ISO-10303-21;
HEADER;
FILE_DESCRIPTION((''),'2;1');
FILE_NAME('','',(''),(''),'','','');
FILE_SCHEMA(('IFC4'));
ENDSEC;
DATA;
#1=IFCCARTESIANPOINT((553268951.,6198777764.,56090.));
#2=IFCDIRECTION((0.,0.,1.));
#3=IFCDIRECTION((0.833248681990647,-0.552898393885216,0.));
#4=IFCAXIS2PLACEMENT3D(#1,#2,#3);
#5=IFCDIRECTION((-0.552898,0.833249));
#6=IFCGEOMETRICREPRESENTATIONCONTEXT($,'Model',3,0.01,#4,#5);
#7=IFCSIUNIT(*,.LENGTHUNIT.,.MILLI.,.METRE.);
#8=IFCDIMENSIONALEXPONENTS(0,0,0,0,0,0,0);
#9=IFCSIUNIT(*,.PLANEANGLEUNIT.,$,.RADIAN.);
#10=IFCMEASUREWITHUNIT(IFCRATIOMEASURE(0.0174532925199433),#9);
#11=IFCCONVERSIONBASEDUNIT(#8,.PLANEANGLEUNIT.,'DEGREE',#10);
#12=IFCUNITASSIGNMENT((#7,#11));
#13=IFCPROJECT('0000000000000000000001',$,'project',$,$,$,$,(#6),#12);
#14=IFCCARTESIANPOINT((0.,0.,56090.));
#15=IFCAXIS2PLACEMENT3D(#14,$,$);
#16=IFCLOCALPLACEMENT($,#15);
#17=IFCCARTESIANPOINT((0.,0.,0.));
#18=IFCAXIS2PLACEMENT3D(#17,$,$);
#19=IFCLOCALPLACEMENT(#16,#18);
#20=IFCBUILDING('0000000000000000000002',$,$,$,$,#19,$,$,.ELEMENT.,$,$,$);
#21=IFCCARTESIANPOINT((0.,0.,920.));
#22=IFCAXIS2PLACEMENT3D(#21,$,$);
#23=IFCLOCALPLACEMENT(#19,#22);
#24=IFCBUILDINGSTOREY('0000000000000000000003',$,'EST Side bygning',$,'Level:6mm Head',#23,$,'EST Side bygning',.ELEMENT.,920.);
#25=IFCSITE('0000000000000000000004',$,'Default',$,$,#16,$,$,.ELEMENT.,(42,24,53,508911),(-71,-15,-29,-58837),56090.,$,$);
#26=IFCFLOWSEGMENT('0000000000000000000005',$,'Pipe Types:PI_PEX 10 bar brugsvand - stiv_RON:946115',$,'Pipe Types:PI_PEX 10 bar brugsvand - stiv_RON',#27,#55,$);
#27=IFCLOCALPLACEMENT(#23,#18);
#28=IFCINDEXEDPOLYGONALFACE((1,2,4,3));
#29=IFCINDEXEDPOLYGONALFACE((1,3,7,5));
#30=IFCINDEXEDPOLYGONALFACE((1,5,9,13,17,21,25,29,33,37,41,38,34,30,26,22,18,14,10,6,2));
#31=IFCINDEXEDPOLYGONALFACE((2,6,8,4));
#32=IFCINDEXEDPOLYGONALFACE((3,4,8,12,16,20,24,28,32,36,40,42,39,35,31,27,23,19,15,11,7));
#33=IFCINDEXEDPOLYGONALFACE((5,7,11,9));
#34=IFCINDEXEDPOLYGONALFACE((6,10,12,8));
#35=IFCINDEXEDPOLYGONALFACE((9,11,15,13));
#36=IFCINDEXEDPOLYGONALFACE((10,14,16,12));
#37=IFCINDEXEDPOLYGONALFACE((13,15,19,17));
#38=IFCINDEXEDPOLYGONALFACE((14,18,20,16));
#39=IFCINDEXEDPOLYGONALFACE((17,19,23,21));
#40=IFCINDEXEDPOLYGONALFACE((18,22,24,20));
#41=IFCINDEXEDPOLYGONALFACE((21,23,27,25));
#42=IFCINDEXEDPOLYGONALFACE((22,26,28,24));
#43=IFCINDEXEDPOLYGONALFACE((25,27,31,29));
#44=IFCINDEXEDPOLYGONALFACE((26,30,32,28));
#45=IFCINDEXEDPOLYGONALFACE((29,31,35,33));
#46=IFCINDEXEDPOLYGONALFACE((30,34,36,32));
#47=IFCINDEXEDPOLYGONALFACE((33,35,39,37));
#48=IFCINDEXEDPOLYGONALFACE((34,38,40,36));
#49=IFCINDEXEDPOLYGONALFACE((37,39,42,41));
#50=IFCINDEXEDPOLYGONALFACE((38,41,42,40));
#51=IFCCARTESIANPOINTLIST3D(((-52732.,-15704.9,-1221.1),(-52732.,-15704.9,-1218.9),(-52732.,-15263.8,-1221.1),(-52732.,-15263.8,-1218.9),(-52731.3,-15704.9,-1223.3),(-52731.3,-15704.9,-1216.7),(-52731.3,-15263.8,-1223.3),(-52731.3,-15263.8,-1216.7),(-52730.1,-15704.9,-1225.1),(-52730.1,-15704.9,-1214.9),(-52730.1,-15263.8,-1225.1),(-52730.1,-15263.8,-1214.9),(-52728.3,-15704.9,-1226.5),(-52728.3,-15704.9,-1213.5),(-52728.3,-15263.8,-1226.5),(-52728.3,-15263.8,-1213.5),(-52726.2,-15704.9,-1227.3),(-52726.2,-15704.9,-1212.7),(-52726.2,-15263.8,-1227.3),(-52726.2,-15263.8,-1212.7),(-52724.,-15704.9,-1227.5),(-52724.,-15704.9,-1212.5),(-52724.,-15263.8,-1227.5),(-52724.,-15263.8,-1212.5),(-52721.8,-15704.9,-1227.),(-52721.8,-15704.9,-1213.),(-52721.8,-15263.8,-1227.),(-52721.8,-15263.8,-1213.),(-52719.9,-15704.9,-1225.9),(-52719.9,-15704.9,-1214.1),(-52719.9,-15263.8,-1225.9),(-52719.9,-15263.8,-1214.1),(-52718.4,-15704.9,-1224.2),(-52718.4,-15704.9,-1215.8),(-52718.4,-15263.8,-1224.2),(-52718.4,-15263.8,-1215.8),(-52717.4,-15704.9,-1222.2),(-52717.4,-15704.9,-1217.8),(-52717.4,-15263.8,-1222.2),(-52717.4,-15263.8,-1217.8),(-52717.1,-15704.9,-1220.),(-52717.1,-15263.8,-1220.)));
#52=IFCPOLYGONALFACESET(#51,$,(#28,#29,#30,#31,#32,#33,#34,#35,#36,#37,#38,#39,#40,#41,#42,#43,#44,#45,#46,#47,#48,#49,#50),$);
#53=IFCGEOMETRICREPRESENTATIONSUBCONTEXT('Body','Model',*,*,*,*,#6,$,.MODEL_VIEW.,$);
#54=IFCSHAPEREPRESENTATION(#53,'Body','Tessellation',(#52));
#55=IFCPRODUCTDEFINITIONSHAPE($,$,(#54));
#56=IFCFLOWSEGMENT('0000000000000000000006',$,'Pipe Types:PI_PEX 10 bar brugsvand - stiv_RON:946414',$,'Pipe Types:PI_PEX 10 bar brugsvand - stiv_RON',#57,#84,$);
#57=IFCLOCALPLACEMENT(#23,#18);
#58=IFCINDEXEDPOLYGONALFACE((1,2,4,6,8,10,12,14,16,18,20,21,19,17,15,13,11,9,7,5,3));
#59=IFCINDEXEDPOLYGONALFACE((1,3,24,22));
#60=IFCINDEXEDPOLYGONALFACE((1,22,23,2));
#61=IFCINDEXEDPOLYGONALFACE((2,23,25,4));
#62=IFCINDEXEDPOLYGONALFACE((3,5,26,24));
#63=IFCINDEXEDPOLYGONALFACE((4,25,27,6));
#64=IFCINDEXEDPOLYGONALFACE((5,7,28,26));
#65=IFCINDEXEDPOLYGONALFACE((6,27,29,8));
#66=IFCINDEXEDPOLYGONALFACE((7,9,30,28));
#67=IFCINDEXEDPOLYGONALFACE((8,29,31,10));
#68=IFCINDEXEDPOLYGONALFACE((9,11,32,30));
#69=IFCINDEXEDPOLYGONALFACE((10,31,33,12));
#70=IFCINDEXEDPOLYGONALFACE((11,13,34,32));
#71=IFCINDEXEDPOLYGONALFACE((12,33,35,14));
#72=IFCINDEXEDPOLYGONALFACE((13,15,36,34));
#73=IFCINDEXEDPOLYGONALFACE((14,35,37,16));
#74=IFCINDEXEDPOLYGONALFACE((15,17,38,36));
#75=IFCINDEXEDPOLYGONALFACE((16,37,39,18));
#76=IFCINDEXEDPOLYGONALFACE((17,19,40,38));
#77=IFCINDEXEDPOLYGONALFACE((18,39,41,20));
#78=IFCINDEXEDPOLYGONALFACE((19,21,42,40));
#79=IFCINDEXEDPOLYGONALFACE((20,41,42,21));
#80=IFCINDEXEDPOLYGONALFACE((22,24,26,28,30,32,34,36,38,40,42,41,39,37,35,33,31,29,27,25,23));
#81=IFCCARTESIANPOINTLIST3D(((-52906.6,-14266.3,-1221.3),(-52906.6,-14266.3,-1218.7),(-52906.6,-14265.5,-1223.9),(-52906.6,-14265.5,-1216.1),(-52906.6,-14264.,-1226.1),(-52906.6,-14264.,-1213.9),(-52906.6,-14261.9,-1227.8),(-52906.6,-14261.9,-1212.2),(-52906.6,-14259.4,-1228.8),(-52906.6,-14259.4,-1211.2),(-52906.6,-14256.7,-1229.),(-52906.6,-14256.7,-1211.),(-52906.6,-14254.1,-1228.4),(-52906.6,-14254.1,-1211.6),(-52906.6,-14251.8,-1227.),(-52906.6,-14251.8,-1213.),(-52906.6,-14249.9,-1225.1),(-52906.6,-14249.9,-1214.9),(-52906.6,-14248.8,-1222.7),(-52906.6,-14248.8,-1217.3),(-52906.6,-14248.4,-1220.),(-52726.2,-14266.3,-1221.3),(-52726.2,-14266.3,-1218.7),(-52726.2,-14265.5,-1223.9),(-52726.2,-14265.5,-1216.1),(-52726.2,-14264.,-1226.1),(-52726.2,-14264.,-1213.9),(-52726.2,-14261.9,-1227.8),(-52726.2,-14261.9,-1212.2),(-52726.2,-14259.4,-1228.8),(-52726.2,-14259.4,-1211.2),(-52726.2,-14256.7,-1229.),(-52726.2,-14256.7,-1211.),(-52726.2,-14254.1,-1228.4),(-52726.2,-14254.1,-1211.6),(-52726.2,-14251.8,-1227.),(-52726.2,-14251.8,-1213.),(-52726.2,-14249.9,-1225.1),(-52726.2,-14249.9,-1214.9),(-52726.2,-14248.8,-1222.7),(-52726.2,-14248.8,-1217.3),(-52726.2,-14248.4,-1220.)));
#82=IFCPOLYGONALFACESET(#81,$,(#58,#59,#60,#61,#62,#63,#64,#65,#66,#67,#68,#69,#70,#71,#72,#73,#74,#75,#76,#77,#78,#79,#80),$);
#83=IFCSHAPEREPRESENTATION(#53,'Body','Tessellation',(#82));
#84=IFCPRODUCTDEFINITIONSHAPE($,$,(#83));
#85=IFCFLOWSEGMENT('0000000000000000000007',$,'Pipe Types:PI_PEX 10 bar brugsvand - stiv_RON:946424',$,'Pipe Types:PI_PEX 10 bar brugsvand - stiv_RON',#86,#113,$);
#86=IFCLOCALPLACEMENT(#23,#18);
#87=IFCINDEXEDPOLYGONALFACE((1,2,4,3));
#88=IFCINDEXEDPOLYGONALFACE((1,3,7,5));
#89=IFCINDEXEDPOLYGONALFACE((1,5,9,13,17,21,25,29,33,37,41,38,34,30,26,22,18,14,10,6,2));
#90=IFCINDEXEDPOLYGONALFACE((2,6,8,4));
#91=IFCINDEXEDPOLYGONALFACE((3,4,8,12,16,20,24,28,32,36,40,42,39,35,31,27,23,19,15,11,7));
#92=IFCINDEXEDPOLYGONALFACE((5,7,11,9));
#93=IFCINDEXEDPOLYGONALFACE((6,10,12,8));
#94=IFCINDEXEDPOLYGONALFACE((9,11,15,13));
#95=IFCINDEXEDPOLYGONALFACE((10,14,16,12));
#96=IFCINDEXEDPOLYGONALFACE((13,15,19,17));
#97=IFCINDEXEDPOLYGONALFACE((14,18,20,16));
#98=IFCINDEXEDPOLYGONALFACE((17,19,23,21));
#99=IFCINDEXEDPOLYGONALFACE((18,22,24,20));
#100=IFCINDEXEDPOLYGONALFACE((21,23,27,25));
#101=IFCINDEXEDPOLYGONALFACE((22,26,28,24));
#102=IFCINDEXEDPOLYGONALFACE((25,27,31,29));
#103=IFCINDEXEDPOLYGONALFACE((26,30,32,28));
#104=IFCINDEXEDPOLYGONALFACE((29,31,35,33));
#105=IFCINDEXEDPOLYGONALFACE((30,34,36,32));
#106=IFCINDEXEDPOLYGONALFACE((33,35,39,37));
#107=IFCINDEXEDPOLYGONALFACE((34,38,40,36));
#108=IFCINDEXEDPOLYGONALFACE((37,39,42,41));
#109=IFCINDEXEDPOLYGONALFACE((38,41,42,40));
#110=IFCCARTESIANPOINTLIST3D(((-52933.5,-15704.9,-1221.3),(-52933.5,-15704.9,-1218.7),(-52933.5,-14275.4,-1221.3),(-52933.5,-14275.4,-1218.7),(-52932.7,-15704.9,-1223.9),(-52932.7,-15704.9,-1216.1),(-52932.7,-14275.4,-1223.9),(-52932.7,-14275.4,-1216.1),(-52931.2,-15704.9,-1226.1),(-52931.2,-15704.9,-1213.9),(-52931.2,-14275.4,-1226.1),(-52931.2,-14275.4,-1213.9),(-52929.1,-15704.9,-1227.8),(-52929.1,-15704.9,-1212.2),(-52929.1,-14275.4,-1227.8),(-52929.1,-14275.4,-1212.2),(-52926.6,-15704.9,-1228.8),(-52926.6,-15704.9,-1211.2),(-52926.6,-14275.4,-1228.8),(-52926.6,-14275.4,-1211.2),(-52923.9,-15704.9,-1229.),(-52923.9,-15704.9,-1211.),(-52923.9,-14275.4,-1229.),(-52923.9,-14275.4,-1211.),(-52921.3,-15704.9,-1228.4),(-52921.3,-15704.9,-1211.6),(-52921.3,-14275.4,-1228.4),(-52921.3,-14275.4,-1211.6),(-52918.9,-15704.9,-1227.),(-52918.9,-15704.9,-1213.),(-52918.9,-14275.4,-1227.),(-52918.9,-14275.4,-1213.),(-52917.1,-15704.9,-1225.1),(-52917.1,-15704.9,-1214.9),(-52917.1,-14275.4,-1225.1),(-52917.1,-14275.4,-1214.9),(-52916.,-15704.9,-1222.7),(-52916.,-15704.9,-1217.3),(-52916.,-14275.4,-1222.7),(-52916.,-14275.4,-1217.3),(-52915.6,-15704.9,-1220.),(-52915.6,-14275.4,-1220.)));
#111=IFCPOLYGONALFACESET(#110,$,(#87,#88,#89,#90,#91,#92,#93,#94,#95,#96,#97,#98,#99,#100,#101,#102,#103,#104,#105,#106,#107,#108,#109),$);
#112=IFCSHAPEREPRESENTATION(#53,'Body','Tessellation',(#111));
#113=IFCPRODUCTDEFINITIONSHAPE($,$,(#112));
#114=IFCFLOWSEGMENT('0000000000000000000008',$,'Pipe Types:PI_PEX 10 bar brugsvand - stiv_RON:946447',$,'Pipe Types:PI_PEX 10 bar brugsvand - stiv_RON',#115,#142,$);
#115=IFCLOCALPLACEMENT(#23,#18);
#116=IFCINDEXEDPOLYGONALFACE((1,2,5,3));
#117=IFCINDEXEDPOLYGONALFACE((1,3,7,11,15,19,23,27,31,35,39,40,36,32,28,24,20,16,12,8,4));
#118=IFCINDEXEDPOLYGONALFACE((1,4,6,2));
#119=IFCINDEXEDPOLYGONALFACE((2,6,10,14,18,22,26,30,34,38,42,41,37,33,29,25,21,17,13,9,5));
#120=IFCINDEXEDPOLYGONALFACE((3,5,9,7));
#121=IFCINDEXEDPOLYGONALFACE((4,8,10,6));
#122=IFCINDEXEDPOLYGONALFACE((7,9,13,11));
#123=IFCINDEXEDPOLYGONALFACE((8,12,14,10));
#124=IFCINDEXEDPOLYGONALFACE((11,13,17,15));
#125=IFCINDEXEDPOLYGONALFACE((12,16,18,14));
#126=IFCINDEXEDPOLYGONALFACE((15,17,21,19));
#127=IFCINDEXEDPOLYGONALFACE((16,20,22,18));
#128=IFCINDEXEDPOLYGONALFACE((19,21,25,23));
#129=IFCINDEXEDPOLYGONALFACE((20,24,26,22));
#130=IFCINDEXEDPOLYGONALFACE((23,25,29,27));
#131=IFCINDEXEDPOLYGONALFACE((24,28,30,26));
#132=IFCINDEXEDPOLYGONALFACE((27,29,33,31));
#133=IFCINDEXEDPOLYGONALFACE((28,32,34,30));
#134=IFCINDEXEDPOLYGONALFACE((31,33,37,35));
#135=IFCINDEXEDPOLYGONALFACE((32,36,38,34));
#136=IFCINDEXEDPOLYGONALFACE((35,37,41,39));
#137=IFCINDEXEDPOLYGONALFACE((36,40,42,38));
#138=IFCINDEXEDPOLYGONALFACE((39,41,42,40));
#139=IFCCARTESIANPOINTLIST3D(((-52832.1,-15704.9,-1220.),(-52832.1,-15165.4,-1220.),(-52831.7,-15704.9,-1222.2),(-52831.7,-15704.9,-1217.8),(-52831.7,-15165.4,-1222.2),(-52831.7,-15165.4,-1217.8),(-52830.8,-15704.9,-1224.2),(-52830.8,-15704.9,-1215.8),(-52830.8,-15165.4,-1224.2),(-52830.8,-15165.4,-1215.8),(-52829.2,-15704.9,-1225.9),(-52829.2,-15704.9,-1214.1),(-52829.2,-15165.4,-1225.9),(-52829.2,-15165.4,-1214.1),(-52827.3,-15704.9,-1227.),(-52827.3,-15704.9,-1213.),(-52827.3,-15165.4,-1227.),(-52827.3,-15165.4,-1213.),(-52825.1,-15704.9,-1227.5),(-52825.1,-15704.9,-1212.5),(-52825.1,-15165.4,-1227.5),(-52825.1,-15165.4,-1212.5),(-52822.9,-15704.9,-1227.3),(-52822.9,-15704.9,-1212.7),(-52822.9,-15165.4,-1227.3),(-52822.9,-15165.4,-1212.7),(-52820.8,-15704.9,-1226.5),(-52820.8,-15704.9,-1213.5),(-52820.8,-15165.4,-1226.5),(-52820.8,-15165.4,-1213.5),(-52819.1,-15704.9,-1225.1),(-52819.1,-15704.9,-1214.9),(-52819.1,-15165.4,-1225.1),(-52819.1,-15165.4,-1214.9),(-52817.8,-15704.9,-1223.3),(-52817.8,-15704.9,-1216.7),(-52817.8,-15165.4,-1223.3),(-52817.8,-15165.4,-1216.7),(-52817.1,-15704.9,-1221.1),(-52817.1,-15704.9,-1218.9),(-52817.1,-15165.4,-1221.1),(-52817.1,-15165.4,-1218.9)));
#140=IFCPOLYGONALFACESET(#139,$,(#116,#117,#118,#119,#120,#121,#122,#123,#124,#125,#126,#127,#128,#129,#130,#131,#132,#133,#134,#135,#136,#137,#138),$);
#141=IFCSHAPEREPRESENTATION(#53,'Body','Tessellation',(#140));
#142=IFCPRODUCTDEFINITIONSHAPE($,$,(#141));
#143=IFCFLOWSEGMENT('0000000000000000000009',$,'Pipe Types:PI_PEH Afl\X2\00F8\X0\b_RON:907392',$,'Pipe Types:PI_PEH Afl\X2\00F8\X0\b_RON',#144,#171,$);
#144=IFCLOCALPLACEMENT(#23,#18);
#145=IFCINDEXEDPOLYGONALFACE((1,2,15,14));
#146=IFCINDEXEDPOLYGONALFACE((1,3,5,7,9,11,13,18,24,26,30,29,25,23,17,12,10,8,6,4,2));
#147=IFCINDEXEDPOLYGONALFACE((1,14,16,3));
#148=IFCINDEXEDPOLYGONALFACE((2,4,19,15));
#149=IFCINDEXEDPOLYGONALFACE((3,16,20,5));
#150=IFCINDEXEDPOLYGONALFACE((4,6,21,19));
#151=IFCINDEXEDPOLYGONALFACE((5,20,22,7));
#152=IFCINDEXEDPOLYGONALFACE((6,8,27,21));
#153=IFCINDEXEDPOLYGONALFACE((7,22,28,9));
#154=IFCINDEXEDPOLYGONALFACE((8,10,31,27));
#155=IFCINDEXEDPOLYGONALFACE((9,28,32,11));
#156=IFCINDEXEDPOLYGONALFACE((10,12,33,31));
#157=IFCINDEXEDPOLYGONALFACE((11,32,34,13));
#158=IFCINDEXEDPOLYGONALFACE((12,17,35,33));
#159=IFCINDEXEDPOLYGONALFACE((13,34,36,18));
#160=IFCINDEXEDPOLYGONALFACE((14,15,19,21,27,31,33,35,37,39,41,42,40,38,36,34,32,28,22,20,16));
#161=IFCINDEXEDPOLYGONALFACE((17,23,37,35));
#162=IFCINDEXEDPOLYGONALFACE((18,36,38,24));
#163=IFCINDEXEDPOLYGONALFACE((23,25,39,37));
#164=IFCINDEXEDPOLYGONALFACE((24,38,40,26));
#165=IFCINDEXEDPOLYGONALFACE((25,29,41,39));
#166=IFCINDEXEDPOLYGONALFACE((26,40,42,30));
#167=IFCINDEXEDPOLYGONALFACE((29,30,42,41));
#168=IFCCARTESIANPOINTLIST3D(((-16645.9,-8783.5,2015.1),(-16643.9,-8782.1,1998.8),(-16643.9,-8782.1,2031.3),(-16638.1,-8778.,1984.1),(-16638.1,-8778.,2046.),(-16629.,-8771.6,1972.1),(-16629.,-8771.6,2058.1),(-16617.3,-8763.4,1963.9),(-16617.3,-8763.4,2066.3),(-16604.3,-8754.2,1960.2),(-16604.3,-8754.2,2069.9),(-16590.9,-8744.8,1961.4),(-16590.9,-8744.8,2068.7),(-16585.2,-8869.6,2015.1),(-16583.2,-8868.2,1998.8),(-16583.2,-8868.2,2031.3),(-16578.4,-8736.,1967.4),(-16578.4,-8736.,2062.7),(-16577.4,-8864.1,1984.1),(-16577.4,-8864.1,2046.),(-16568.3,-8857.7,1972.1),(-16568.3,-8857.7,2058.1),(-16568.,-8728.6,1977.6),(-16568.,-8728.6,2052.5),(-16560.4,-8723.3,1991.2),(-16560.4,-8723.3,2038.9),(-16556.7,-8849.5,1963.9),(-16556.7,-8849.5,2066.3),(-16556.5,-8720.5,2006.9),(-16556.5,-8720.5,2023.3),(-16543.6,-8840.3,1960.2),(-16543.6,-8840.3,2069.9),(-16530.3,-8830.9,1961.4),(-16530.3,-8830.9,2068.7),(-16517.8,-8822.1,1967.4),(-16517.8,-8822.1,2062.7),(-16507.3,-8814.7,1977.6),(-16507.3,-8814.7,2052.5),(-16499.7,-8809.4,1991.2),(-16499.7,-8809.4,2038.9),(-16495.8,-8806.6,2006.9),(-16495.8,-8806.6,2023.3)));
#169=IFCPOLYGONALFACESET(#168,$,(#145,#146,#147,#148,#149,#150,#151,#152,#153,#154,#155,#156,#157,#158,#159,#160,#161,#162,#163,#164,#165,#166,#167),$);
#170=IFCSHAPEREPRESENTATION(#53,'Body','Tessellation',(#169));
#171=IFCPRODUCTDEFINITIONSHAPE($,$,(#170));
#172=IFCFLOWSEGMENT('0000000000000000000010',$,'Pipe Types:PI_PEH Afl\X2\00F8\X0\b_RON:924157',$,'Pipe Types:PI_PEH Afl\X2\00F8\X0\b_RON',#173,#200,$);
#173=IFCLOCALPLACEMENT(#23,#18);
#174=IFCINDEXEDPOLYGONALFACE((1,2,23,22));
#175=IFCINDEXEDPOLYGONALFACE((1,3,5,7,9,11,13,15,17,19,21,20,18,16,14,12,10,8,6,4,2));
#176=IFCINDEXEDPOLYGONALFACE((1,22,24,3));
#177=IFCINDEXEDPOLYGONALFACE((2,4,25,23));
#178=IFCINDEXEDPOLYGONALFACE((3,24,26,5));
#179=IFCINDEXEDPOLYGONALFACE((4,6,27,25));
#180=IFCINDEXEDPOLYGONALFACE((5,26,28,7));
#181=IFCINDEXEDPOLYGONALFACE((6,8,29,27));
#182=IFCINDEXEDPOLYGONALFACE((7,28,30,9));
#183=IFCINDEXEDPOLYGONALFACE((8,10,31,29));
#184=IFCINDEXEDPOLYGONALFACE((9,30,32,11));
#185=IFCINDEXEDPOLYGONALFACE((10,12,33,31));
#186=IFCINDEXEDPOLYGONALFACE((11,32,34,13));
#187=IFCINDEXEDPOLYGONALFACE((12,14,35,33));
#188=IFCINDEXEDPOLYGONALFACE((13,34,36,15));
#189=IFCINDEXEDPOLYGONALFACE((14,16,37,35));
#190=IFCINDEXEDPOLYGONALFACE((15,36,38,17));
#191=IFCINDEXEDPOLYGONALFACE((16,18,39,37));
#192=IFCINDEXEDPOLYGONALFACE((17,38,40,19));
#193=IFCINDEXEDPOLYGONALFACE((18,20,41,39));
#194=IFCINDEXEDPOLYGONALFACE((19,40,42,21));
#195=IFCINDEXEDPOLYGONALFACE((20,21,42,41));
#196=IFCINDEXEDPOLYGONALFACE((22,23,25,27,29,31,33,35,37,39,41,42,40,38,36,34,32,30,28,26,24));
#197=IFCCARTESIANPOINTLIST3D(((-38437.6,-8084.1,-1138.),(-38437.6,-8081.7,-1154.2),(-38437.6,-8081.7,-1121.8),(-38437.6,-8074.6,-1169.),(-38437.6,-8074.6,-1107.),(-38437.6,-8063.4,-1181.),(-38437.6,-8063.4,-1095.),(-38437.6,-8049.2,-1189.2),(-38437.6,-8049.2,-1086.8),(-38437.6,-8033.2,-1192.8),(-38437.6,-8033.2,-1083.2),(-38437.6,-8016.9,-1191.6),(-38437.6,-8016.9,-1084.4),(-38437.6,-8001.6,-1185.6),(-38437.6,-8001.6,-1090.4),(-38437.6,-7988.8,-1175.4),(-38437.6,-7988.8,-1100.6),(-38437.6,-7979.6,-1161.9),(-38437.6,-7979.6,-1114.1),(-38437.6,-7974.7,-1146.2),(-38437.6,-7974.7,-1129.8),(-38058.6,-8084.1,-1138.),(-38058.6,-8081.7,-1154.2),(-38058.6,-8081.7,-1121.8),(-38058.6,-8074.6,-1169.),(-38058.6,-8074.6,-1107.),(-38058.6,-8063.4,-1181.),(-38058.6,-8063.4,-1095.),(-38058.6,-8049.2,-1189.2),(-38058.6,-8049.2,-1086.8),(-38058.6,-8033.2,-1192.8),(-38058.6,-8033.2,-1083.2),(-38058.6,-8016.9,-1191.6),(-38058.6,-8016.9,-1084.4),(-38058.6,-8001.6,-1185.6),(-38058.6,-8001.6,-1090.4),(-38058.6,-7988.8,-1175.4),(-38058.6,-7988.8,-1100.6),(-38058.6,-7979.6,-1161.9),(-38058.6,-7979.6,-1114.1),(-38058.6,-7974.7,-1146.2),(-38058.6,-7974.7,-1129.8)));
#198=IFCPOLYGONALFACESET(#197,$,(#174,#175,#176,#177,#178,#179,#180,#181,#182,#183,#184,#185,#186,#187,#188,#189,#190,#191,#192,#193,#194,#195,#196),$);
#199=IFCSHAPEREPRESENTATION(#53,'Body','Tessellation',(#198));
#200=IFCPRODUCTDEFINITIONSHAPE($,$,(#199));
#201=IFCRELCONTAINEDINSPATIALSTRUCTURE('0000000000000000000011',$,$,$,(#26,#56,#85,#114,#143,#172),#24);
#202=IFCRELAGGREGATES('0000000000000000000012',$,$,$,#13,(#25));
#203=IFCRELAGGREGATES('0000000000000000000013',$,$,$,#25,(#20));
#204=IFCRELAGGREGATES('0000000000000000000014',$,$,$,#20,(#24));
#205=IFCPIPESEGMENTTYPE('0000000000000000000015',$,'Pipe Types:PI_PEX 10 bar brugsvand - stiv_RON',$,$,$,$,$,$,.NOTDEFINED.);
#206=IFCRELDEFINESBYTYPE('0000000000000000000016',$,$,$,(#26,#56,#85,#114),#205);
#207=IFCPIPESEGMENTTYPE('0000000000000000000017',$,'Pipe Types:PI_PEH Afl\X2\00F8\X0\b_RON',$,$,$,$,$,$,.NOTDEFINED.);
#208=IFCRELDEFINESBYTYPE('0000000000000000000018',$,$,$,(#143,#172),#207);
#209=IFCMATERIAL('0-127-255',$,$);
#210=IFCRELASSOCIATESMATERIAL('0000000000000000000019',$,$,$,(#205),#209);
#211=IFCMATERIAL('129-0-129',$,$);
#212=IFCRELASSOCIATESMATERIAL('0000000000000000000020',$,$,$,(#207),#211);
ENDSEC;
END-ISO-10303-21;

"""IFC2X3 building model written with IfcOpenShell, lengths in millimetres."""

from ifc_helpers import new_model, entity, si_unit, converted_unit, direction, frame, frame_2d, origin, origin_2d_with_axis, place, context, subcontext, project, spatial, circle, extrude, material, type_object, element, save


model = new_model("IFC2X3")

# Units and contexts
model_context = context("Model", 3, precision=0.01, world=frame((553268951.0, 6198777764.0, 56090.0), z_axis=(0.0, 0.0, 1.0), x_axis=(0.833248681990647, -0.552898393885216, 0.0)), true_north=direction((-0.552898, 0.833249)))
body_context = subcontext(model_context, "Body", "Model", "MODEL_VIEW")
ifc_project = project(units=[si_unit("LENGTHUNIT", "METRE", prefix="MILLI"), converted_unit("PLANEANGLEUNIT", "DEGREE", entity("IfcRatioMeasure", 0.0174532925199433), si_unit("PLANEANGLEUNIT", "RADIAN"), dimensions=[0, 0, 0, 0, 0, 0, 0])], contexts=[model_context])

# Site, building, storey
site_placement = place(None, frame((0.0, 0.0, 56090.0)))
site = spatial("IfcSite", under=ifc_project, at=site_placement, Name="Default", CompositionType="ELEMENT", RefLatitude=(42, 24, 53, 508911), RefLongitude=(-71, -15, -29, -58837), RefElevation=56090.0)
building_placement = place(site_placement, origin())
building = spatial("IfcBuilding", under=site, at=building_placement, CompositionType="ELEMENT")
storey_placement = place(building_placement, frame((0.0, 0.0, 920.0)))
storey = spatial("IfcBuildingStorey", under=building, at=storey_placement, Name="EST Side bygning", ObjectType="Level:6mm Head", LongName="EST Side bygning", CompositionType="ELEMENT", Elevation=920.0)

# Flow segments
ifc_material_1 = material(Name="0-127-255")
pipe_segment_type_1 = type_object("IfcPipeSegmentType", Name="Pipe Types:PI_PEX 10 bar brugsvand - stiv_RON", PredefinedType="NOTDEFINED", material=ifc_material_1)
flow_segment_1_placement = place(storey_placement, origin())
element("IfcFlowSegment", 1, at=flow_segment_1_placement, inside=storey, type_object=pipe_segment_type_1, Name="Pipe Types:PI_PEX 10 bar brugsvand - stiv_RON:946115", ObjectType="Pipe Types:PI_PEX 10 bar brugsvand - stiv_RON", context=body_context, shape_type="SweptSolid", body=[
    extrude(circle(Radius=7.5, at=origin_2d_with_axis()), frame((-52724.6, -15704.9, -1220.0), z_axis=(0.0, 1.0, 0.0), x_axis=(1.0, 0.0, 0.0)), (0.0, 0.0, 1.0), 441.0),
])
flow_segment_2_placement = place(storey_placement, origin())
element("IfcFlowSegment", 2, at=flow_segment_2_placement, inside=storey, type_object=pipe_segment_type_1, Name="Pipe Types:PI_PEX 10 bar brugsvand - stiv_RON:946414", ObjectType="Pipe Types:PI_PEX 10 bar brugsvand - stiv_RON", context=body_context, shape_type="SweptSolid", body=[
    extrude(circle(Radius=9.0, at=origin_2d_with_axis()), frame((-52906.6, -14257.4, -1220.0), z_axis=(1.0, 0.0, 0.0), x_axis=(0.0, 1.0, 0.0)), (0.0, 0.0, 1.0), 180.4),
])
flow_segment_3_placement = place(storey_placement, origin())
element("IfcFlowSegment", 3, at=flow_segment_3_placement, inside=storey, type_object=pipe_segment_type_1, Name="Pipe Types:PI_PEX 10 bar brugsvand - stiv_RON:946424", ObjectType="Pipe Types:PI_PEX 10 bar brugsvand - stiv_RON", context=body_context, shape_type="SweptSolid", body=[
    extrude(circle(Radius=9.0, at=origin_2d_with_axis()), frame((-52924.6, -15704.9, -1220.0), z_axis=(0.0, 1.0, 0.0), x_axis=(1.0, 0.0, 0.0)), (0.0, 0.0, 1.0), 1429.5),
])
flow_segment_4_placement = place(storey_placement, origin())
element("IfcFlowSegment", 4, at=flow_segment_4_placement, inside=storey, type_object=pipe_segment_type_1, Name="Pipe Types:PI_PEX 10 bar brugsvand - stiv_RON:946447", ObjectType="Pipe Types:PI_PEX 10 bar brugsvand - stiv_RON", context=body_context, shape_type="SweptSolid", body=[
    extrude(circle(Radius=7.5, at=origin_2d_with_axis()), frame((-52824.6, -15704.9, -1220.0), z_axis=(0.0, 1.0, 0.0), x_axis=(-1.0, 0.0, 0.0)), (0.0, 0.0, 1.0), 539.5),
])
ifc_material_2 = material(Name="129-0-129")
pipe_segment_type_2 = type_object("IfcPipeSegmentType", Name="Pipe Types:PI_PEH Afløb_RON", PredefinedType="NOTDEFINED", material=ifc_material_2)
flow_segment_5_placement = place(storey_placement, origin())
element("IfcFlowSegment", 5, at=flow_segment_5_placement, inside=storey, type_object=pipe_segment_type_2, Name="Pipe Types:PI_PEH Afløb_RON:907392", ObjectType="Pipe Types:PI_PEH Afløb_RON", context=body_context, shape_type="SweptSolid", body=[
    extrude(circle(Radius=55.0, at=origin_2d_with_axis()), frame((-16540.3, -8838.0, 2015.1), z_axis=(-0.575779, 0.817606, 0.0), x_axis=(-0.817606, -0.575779, 0.0)), (0.0, 0.0, 1.0), 105.4),
])
flow_segment_6_placement = place(storey_placement, origin())
element("IfcFlowSegment", 6, at=flow_segment_6_placement, inside=storey, type_object=pipe_segment_type_2, Name="Pipe Types:PI_PEH Afløb_RON:924157", ObjectType="Pipe Types:PI_PEH Afløb_RON", context=body_context, shape_type="SweptSolid", body=[
    extrude(circle(Radius=55.0, at=frame_2d((0.0, 0.0), x_axis=(1.0, 0.0))), frame((-38437.6, -8029.1, -1138.0), z_axis=(1.0, 0.0, 0.0), x_axis=(0.0, -1.0, 0.0)), (0.0, 0.0, 1.0), 379.0),
])

save(model, "model.ifc")
